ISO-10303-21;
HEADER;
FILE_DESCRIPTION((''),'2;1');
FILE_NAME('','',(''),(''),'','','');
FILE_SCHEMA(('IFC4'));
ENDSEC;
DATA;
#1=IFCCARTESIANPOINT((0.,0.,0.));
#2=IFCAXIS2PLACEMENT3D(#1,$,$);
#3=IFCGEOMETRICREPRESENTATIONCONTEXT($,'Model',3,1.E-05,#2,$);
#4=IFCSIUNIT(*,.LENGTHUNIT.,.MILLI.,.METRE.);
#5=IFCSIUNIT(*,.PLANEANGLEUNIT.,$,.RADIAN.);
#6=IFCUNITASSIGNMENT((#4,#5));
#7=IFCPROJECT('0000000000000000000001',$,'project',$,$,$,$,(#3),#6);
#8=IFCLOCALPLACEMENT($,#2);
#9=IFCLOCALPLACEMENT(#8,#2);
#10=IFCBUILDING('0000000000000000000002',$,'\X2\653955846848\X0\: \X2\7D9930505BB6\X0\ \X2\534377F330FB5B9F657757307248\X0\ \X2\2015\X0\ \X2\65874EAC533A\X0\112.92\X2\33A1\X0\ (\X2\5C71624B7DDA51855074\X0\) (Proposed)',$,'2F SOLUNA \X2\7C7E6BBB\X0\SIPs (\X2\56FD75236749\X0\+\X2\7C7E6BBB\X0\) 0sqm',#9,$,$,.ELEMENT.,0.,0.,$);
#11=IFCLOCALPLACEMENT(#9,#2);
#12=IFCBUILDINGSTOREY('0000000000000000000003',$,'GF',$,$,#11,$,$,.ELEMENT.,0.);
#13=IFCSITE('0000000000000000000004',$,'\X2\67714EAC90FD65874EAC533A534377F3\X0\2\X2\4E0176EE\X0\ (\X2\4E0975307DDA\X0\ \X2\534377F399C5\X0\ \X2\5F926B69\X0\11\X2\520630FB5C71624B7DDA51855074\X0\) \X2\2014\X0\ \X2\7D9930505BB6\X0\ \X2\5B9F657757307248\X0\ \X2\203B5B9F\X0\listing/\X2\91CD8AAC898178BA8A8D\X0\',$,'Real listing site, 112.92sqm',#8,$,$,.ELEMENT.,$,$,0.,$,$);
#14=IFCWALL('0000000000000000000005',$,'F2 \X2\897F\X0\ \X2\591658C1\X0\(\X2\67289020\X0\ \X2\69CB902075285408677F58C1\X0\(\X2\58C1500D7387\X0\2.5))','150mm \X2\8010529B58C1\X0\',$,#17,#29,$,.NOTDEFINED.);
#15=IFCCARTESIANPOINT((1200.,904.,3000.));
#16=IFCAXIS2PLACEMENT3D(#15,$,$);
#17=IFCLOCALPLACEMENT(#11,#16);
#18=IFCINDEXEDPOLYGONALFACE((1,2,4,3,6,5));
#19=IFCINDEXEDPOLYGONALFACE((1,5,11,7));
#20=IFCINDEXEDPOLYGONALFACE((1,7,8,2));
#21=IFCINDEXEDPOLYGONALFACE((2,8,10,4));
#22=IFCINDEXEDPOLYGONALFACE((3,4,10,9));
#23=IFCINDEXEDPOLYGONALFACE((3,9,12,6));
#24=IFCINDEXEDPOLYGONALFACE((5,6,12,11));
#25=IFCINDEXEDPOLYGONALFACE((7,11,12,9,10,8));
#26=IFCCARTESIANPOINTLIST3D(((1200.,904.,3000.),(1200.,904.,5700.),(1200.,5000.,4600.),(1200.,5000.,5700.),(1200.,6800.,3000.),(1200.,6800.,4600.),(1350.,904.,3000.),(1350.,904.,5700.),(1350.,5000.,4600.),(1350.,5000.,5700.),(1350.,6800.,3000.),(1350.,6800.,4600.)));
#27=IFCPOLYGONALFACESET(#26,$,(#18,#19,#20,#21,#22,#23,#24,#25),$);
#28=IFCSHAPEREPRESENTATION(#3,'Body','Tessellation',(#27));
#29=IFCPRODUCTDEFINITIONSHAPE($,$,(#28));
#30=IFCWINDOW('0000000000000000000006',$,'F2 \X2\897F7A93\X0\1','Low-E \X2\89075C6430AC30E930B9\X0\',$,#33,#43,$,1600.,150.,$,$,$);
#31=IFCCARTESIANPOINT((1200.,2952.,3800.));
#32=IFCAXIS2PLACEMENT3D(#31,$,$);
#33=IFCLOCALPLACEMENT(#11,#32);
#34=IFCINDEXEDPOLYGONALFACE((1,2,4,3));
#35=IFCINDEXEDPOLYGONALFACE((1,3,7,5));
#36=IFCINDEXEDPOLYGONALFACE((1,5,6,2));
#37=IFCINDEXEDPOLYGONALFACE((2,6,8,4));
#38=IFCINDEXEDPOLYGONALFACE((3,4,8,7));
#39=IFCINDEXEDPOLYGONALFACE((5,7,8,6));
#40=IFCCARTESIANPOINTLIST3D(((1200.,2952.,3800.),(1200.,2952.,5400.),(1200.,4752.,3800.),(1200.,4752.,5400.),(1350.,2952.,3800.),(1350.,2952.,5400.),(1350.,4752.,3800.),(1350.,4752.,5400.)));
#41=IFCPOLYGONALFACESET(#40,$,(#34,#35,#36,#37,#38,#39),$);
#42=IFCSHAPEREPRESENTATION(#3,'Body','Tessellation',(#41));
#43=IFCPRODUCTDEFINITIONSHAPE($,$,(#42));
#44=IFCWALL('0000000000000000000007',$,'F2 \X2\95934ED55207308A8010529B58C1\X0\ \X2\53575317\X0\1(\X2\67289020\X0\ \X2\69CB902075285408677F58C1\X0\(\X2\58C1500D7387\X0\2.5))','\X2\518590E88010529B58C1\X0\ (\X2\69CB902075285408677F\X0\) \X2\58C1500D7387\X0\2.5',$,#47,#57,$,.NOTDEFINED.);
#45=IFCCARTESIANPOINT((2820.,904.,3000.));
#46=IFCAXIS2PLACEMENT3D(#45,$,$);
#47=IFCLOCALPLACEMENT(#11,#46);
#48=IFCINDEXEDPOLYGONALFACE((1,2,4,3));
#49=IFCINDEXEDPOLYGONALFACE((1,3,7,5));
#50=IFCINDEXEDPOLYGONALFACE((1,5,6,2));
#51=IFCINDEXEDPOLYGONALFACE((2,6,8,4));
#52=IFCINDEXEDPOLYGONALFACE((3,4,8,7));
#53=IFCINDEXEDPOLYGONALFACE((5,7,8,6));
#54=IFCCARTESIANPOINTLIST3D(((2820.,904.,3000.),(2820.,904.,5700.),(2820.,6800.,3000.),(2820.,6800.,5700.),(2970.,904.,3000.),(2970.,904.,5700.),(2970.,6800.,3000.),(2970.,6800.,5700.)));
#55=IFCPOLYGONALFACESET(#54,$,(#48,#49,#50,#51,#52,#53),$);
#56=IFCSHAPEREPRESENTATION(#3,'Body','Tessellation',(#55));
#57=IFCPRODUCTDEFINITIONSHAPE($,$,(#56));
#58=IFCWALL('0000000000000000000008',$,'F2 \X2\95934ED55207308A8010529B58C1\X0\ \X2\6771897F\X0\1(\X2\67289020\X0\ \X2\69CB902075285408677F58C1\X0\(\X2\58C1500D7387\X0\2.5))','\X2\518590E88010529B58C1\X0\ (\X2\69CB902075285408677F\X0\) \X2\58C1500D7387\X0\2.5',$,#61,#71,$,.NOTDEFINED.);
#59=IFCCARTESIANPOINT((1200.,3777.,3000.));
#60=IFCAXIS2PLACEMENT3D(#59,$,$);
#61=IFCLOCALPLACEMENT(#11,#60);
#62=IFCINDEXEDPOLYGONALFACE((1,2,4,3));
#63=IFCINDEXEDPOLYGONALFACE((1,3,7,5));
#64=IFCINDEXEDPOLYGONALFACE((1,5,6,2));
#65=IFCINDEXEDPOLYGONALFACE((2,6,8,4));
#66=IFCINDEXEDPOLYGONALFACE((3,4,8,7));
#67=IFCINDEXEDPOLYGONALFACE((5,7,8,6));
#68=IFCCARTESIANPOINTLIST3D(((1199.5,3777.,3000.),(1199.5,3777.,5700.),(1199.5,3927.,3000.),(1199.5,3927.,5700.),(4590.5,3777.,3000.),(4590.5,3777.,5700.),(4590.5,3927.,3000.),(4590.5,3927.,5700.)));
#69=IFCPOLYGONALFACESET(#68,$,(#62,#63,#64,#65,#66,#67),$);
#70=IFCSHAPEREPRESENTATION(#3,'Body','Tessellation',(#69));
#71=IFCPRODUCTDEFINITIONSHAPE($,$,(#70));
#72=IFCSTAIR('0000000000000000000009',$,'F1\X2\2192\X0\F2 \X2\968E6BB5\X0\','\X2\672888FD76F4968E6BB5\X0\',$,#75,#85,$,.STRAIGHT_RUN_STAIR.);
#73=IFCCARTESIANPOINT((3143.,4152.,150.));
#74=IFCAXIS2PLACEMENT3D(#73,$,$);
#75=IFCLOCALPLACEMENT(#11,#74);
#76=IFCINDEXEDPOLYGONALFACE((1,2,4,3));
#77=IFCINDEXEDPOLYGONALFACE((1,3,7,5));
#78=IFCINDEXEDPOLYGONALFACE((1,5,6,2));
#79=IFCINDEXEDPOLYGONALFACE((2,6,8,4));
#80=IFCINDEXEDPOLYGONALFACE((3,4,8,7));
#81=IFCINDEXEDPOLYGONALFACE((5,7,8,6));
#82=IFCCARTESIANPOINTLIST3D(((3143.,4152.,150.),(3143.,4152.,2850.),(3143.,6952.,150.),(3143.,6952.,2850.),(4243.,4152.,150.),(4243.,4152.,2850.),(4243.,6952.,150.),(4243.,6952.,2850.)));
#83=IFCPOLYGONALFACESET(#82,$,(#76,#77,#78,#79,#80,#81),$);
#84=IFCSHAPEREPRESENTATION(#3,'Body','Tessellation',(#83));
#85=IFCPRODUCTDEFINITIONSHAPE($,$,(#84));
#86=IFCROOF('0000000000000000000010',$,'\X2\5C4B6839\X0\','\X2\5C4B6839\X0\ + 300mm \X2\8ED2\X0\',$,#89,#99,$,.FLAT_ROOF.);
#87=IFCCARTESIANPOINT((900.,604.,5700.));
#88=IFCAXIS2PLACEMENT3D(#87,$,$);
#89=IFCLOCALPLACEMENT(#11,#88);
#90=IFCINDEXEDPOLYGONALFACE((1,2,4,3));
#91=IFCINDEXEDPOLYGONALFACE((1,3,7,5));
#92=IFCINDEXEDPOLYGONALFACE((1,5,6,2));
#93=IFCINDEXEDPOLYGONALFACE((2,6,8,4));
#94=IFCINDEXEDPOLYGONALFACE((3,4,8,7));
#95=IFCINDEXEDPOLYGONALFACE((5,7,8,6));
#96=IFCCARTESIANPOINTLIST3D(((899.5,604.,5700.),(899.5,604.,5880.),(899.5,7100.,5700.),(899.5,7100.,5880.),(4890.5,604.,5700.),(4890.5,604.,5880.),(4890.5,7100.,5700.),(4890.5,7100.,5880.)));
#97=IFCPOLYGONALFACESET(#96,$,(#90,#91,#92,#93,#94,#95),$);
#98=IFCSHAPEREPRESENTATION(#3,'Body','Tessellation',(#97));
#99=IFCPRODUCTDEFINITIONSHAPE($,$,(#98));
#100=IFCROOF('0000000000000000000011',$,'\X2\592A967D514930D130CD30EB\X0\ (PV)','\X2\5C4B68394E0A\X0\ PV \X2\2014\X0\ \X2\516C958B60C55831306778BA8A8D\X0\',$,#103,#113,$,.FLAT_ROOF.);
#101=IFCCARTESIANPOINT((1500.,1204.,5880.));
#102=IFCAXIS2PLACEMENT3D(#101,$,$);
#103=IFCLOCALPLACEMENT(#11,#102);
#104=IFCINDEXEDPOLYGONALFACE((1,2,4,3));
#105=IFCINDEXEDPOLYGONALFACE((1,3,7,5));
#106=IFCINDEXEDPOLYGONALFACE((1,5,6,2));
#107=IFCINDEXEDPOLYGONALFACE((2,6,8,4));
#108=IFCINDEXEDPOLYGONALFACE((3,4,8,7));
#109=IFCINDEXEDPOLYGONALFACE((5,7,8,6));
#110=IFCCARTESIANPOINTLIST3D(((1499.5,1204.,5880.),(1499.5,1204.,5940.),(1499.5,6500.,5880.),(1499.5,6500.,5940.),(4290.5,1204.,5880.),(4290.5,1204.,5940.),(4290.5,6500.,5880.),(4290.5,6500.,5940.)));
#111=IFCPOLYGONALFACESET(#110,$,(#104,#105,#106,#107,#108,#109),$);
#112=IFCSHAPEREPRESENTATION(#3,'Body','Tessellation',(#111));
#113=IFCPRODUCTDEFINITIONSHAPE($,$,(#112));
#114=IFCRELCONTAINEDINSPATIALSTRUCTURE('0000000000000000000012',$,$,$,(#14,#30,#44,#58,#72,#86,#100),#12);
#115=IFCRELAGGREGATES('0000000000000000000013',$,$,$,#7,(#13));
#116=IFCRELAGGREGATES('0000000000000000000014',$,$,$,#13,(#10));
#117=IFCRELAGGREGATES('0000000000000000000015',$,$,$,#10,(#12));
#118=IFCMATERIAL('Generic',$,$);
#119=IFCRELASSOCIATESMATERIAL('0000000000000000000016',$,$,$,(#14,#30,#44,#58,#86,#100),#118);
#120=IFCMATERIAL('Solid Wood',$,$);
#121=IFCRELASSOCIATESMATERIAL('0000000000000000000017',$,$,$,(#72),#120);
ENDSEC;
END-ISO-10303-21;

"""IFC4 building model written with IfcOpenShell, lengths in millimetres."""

from ifc_helpers import new_model, si_unit, frame, frame_2d, origin, place, context, project, spatial, rectangle, extrude, material, element, fill, save


model = new_model("IFC4")

# Units and contexts
model_context = context("Model", 3, precision=1e-05, world=origin())
ifc_project = project(units=[si_unit("LENGTHUNIT", "METRE", prefix="MILLI"), si_unit("PLANEANGLEUNIT", "RADIAN")], contexts=[model_context])

# Site, building, storey
site_placement = place(None, origin())
site = spatial("IfcSite", under=ifc_project, at=site_placement, Name="東京都文京区千石2丁目 (三田線 千石駅 徒歩11分・山手線内側) — 継ぐ家 実敷地版 ※実listing/重説要確認", ObjectType="Real listing site, 112.92sqm", CompositionType="ELEMENT", RefElevation=0.0)
building_placement = place(site_placement, origin())
building = spatial("IfcBuilding", under=site, at=building_placement, Name="改善案: 継ぐ家 千石・実敷地版 ― 文京区112.92㎡ (山手線内側) (Proposed)", ObjectType="2F SOLUNA 籾殻SIPs (国産杉+籾殻) 0sqm", CompositionType="ELEMENT", ElevationOfRefHeight=0.0, ElevationOfTerrain=0.0)
storey_placement = place(building_placement, origin())
storey = spatial("IfcBuildingStorey", under=building, at=storey_placement, Name="GF", CompositionType="ELEMENT", Elevation=0.0)

# Shared definitions
ifc_material_1 = material(Name="Generic")

# Shared definitions
ifc_material_2 = material(Name="Solid Wood")

# Wall, opening, window
wall_1_placement = place(storey_placement, frame((1200.0, 904.0, 3000.0)))
wall_1 = element("IfcWall", 1, at=wall_1_placement, inside=storey, material=ifc_material_1, Name="F2 西 外壁(木造 構造用合板壁(壁倍率2.5))", Description="150mm 耐力壁", PredefinedType="NOTDEFINED", context=model_context, shape_type="SweptSolid", body=[
    extrude(rectangle(XDim=150.0, YDim=5896.0, at=frame_2d((75.0, 2948.0))), frame((1200.0, 904.0, 3000.0)), (0.0, 0.0, 1.0), 2700.0),
])
opening_1_placement = place(storey_placement, frame((1200.0, 2952.0, 3800.0)))
opening_1 = element("IfcOpeningElement", 2, at=opening_1_placement, cuts=wall_1, PredefinedType="NOTDEFINED", context=model_context, shape_type="SweptSolid", body=[
    extrude(rectangle(XDim=150.0, YDim=1800.0, at=frame_2d((75.0, 900.0))), frame((1200.0, 2952.0, 3800.0)), (0.0, 0.0, 1.0), 1600.0),
])
window_1_placement = place(storey_placement, frame((1200.0, 2952.0, 3800.0)))
window_1 = element("IfcWindow", 3, at=window_1_placement, inside=storey, material=ifc_material_1, Name="F2 西窓1", Description="Low-E 複層ガラス", OverallHeight=1600.0, OverallWidth=150.0, context=model_context, shape_type="SweptSolid", body=[
    extrude(rectangle(XDim=150.0, YDim=1800.0, at=frame_2d((75.0, 900.0))), frame((1200.0, 2952.0, 3800.0)), (0.0, 0.0, 1.0), 1600.0),
])
fill(opening_1, window_1)

# Walls
wall_2_placement = place(storey_placement, frame((2820.0, 904.0, 3000.0)))
element("IfcWall", 4, at=wall_2_placement, inside=storey, material=ifc_material_1, Name="F2 間仕切り耐力壁 南北1(木造 構造用合板壁(壁倍率2.5))", Description="内部耐力壁 (構造用合板) 壁倍率2.5", PredefinedType="NOTDEFINED", context=model_context, shape_type="SweptSolid", body=[
    extrude(rectangle(XDim=150.0, YDim=5896.0, at=frame_2d((75.0, 2948.0))), frame((2820.0, 904.0, 3000.0)), (0.0, 0.0, 1.0), 2700.0),
])
wall_3_placement = place(storey_placement, frame((1200.0, 3777.0, 3000.0)))
element("IfcWall", 5, at=wall_3_placement, inside=storey, material=ifc_material_1, Name="F2 間仕切り耐力壁 東西1(木造 構造用合板壁(壁倍率2.5))", Description="内部耐力壁 (構造用合板) 壁倍率2.5", PredefinedType="NOTDEFINED", context=model_context, shape_type="SweptSolid", body=[
    extrude(rectangle(XDim=3391.0, YDim=150.0, at=frame_2d((1695.0, 75.0))), frame((1200.0, 3777.0, 3000.0)), (0.0, 0.0, 1.0), 2700.0),
])

# Stair
stair_placement = place(storey_placement, frame((3143.0, 4152.0, 150.0)))
element("IfcStair", 6, at=stair_placement, inside=storey, material=ifc_material_2, Name="F1→F2 階段", Description="木製直階段", PredefinedType="STRAIGHT_RUN_STAIR", context=model_context, shape_type="SweptSolid", body=[
    extrude(rectangle(XDim=1100.0, YDim=2800.0, at=frame_2d((550.0, 1400.0))), frame((3143.0, 4152.0, 150.0)), (0.0, 0.0, 1.0), 2700.0),
])

# Roofs
roof_1_placement = place(storey_placement, frame((900.0, 604.0, 5700.0)))
element("IfcRoof", 7, at=roof_1_placement, inside=storey, material=ifc_material_1, Name="屋根", Description="屋根 + 300mm 軒", PredefinedType="FLAT_ROOF", context=model_context, shape_type="SweptSolid", body=[
    extrude(rectangle(XDim=3991.0, YDim=6496.0, at=frame_2d((1995.0, 3248.0))), frame((900.0, 604.0, 5700.0)), (0.0, 0.0, 1.0), 180.0),
])
roof_2_placement = place(storey_placement, frame((1500.0, 1204.0, 5880.0)))
element("IfcRoof", 8, at=roof_2_placement, inside=storey, material=ifc_material_1, Name="太陽光パネル (PV)", Description="屋根上 PV — 公開情報で確認", PredefinedType="FLAT_ROOF", context=model_context, shape_type="SweptSolid", body=[
    extrude(rectangle(XDim=2791.0, YDim=5296.0, at=frame_2d((1395.0, 2648.0))), frame((1500.0, 1204.0, 5880.0)), (0.0, 0.0, 1.0), 60.0),
])

save(model, "model.ifc")
